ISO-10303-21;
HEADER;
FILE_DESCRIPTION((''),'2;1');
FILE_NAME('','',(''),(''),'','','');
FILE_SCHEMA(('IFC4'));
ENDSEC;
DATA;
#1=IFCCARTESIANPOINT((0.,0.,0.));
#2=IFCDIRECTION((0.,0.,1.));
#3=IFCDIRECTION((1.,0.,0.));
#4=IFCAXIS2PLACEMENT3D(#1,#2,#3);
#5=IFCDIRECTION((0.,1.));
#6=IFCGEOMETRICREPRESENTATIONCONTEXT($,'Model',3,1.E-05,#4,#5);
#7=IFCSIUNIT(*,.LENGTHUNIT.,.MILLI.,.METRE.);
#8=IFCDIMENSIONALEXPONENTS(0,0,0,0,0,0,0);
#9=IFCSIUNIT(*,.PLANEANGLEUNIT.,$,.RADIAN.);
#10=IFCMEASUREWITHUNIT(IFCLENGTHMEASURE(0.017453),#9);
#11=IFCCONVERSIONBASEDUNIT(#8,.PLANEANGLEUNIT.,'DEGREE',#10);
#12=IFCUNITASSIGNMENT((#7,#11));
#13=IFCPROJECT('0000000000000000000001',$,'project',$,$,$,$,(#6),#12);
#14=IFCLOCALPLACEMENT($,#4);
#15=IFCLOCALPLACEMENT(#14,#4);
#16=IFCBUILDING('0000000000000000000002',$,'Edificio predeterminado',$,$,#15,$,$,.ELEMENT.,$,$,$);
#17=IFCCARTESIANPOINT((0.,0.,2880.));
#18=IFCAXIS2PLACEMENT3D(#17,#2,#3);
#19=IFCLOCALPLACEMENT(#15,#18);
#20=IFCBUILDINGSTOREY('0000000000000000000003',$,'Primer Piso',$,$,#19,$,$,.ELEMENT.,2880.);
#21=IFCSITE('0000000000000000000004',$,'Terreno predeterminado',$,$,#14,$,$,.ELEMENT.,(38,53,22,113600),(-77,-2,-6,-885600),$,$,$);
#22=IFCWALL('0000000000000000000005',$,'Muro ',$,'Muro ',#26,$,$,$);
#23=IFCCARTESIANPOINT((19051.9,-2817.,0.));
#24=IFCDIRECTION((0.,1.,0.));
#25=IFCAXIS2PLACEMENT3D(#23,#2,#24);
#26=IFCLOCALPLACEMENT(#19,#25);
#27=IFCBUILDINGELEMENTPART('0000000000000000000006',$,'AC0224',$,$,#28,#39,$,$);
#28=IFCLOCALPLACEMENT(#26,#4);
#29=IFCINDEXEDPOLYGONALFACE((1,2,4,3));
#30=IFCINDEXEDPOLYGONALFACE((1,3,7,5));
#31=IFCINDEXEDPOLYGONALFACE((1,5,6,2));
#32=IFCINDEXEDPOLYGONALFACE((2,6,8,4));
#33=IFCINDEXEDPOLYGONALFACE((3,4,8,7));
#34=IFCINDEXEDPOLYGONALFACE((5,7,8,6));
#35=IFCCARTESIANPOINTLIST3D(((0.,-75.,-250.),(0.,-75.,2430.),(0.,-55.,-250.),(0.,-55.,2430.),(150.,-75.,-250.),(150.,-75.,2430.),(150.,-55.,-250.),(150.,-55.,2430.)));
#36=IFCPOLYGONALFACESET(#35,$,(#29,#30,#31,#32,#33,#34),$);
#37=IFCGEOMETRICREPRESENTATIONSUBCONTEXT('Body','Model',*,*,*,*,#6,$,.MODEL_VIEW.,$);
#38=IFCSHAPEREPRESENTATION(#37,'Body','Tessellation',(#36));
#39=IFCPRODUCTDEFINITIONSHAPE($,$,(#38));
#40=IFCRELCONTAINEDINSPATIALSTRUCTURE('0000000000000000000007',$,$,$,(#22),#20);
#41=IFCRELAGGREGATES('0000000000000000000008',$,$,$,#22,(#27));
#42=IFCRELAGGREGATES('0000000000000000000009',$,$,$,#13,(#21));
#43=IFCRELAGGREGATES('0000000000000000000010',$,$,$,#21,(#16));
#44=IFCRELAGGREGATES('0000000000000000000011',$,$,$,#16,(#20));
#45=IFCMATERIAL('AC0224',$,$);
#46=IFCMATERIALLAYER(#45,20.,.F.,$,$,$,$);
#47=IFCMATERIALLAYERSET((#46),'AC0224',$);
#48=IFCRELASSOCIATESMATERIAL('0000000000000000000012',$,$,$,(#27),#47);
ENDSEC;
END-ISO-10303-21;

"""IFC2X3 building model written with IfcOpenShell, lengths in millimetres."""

from ifc_helpers import new_model, entity, si_unit, converted_unit, direction, frame, origin_with_axes, place, context, subcontext, project, spatial, polyline, outline, extrude, clip, bounded_halfspace, material, layer, layer_set, layer_usage, element, aggregate, save


model = new_model("IFC2X3")

# Units and contexts
model_context = context("Model", 3, precision=1e-05, world=origin_with_axes(), true_north=direction((0.0, 1.0)))
body_context = subcontext(model_context, "Body", "Model", "MODEL_VIEW")
ifc_project = project(units=[si_unit("LENGTHUNIT", "METRE", prefix="MILLI"), converted_unit("PLANEANGLEUNIT", "DEGREE", entity("IfcLengthMeasure", 0.017453), si_unit("PLANEANGLEUNIT", "RADIAN"), dimensions=[0, 0, 0, 0, 0, 0, 0])], contexts=[model_context])

# Site, building, storey
site_placement = place(None, origin_with_axes())
site = spatial("IfcSite", under=ifc_project, at=site_placement, Name="Terreno predeterminado", CompositionType="ELEMENT", RefLatitude=(38, 53, 22, 113600), RefLongitude=(-77, -2, -6, -885600))
building_placement = place(site_placement, origin_with_axes())
building = spatial("IfcBuilding", under=site, at=building_placement, Name="Edificio predeterminado", CompositionType="ELEMENT")
storey_placement = place(building_placement, frame((0.0, 0.0, 2880.0), z_axis=(0.0, 0.0, 1.0), x_axis=(1.0, 0.0, 0.0)))
storey = spatial("IfcBuildingStorey", under=building, at=storey_placement, Name="Primer Piso", CompositionType="ELEMENT", Elevation=2880.0)

# Wall, building element part
wall_1_placement = place(storey_placement, frame((19051.9, -2817.0, 0.0), z_axis=(0.0, 0.0, 1.0), x_axis=(0.0, 1.0, 0.0)))
wall_1 = element("IfcWall", 1, at=wall_1_placement, inside=storey, Name="Muro ", ObjectType="Muro ")
ifc_material_1 = material(Name="AC0224")
ifc_layer_1 = layer(ifc_material_1, 20.0, ventilated=False)
ifc_layer_set_1 = layer_set([ifc_layer_1], Name="AC0224")
ifc_layer_usage_1 = layer_usage(ifc_layer_set_1, "AXIS2", "NEGATIVE", 55.0)
building_element_part_1_placement = place(wall_1_placement, origin_with_axes())
building_element_part_1 = element("IfcBuildingElementPart", 2, at=building_element_part_1_placement, material=ifc_layer_usage_1, Name="AC0224", context=body_context, shape_type="Clipping", body=[
    clip(clip(extrude(outline(polyline([(150.0, -55.0), (150.0, -75.0), (0.0, -75.0), (0.0, -55.0), (150.0, -55.0)])), frame((0.0, 0.0, -250.0), z_axis=(0.0, 0.0, 1.0), x_axis=(1.0, 0.0, 0.0)), (0.0, 0.0, 1.0), 2680.0), bounded_halfspace(frame((0.0, 0.0, -250.0), z_axis=(0.0, 0.0, 1.0), x_axis=(1.0, 0.0, 0.0)), True, origin_with_axes(), polyline([(-150.0, -150.0), (375.0, -150.0), (375.0, 150.0), (-150.0, 150.0), (-150.0, -150.0)]))), bounded_halfspace(frame((0.0, 0.0, 2430.0), z_axis=(0.0, 0.0, 1.0), x_axis=(1.0, 0.0, 0.0)), False, origin_with_axes(), polyline([(-150.0, -150.0), (375.0, -150.0), (375.0, 150.0), (-150.0, 150.0), (-150.0, -150.0)]))),
])
aggregate(wall_1, [building_element_part_1])

save(model, "model.ifc")
